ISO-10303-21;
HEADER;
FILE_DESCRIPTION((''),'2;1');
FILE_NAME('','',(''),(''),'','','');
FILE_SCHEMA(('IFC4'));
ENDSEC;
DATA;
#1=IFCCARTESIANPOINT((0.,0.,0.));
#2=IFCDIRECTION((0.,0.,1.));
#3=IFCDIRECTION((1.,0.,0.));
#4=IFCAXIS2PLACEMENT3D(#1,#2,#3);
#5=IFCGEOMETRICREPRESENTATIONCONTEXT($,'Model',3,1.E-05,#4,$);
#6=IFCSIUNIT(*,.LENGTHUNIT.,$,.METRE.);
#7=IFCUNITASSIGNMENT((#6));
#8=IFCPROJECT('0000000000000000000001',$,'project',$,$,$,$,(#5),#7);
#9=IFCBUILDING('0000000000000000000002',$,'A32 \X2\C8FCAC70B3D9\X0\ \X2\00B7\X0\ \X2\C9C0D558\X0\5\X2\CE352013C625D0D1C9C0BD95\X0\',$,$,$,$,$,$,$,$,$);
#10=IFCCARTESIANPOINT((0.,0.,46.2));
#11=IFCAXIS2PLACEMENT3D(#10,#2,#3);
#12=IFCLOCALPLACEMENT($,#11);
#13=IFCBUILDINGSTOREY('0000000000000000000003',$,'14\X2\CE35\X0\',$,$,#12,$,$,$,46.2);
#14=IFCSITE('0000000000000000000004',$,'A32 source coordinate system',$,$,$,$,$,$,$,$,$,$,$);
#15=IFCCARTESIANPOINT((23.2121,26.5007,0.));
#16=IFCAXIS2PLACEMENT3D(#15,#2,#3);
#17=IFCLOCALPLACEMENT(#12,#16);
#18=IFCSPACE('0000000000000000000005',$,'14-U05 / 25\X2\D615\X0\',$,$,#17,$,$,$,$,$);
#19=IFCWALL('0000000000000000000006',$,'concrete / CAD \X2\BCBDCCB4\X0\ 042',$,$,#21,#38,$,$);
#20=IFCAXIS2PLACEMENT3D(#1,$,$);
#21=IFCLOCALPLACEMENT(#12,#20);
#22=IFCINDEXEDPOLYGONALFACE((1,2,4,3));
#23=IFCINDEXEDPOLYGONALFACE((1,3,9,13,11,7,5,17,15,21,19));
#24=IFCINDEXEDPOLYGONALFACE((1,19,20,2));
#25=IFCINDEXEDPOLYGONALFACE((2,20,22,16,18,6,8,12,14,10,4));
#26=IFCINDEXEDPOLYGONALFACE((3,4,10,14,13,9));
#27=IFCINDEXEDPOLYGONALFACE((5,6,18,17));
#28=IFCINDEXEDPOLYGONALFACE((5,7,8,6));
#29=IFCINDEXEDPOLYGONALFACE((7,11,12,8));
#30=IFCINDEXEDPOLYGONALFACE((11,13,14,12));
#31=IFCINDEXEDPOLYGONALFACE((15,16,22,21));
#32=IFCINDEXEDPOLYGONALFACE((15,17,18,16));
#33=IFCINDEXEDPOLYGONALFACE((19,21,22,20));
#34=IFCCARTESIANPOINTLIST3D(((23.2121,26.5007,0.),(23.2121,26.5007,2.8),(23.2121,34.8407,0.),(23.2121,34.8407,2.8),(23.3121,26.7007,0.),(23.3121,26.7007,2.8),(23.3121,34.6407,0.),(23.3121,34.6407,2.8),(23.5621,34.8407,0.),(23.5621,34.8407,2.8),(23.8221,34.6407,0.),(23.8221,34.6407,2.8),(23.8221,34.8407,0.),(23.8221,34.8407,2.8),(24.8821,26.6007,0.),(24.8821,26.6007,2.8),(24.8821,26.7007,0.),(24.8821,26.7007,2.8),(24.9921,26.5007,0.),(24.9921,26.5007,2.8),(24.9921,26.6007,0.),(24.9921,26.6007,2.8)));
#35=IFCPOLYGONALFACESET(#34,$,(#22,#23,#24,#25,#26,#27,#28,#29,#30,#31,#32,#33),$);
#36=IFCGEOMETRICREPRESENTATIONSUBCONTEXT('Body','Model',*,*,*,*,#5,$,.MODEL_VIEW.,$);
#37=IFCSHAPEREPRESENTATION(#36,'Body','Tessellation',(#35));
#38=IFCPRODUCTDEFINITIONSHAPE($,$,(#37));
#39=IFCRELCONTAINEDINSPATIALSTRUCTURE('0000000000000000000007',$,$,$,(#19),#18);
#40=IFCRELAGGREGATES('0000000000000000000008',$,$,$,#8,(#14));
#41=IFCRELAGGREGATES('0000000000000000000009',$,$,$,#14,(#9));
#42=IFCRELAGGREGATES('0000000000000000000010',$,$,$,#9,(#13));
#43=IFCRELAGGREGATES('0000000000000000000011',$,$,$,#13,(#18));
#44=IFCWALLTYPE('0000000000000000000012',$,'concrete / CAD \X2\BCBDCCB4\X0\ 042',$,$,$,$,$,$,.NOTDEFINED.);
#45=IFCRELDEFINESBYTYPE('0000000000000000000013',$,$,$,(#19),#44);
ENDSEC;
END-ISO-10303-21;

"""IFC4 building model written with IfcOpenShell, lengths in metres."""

from ifc_helpers import new_model, si_unit, frame, origin, origin_with_axes, place, context, subcontext, project, spatial, polyline, outline, extrude, source, transform, mapped, type_object, type_shapes, element, save


model = new_model("IFC4")

# Units and contexts
model_context = context("Model", 3, precision=1e-05, world=origin_with_axes())
body_context = subcontext(model_context, "Body", "Model", "MODEL_VIEW")
ifc_project = project(units=[si_unit("LENGTHUNIT", "METRE")], contexts=[model_context])

# Site, building, storey, space
site = spatial("IfcSite", under=ifc_project, Name="A32 source coordinate system")
building = spatial("IfcBuilding", under=site, Name="A32 주거동 · 지하5층–옥탑지붕")
storey_placement = place(None, frame((0.0, 0.0, 46.2), z_axis=(0.0, 0.0, 1.0), x_axis=(1.0, 0.0, 0.0)))
storey = spatial("IfcBuildingStorey", under=building, at=storey_placement, Name="14층", Elevation=46.2)
space_1_placement = place(storey_placement, frame((23.2121, 26.5007, 0.0), z_axis=(0.0, 0.0, 1.0), x_axis=(1.0, 0.0, 0.0)))
space_1 = spatial("IfcSpace", under=storey, at=space_1_placement, Name="14-U05 / 25형")

# Wall
wall_type_1 = type_object("IfcWallType", Name="concrete / CAD 벽체 042", PredefinedType="NOTDEFINED")
shared_shape_1 = source(origin(), body_context, "Body", "SweptSolid", [
    extrude(outline(polyline([(0.1, 8.14), (0.1, 0.2), (1.67, 0.2), (1.67, 0.1), (1.78, 0.1), (1.78, 0.0), (0.0, 0.0), (0.0, 8.34), (0.35, 8.34), (0.35, 8.34), (0.61, 8.34), (0.61, 8.14), (0.1, 8.14)])), origin(), (0.0, 0.0, 1.0), 2.8),
])
type_shapes(wall_type_1, [shared_shape_1])
wall_1_placement = place(space_1_placement, origin_with_axes())
element("IfcWall", 1, at=wall_1_placement, inside=space_1, type_object=wall_type_1, Name="concrete / CAD 벽체 042", context=body_context, shape_type="MappedRepresentation", body=[
    mapped(shared_shape_1, transform((0.0, 0.0, 0.0), scale=1.0)),
])

save(model, "model.ifc")
